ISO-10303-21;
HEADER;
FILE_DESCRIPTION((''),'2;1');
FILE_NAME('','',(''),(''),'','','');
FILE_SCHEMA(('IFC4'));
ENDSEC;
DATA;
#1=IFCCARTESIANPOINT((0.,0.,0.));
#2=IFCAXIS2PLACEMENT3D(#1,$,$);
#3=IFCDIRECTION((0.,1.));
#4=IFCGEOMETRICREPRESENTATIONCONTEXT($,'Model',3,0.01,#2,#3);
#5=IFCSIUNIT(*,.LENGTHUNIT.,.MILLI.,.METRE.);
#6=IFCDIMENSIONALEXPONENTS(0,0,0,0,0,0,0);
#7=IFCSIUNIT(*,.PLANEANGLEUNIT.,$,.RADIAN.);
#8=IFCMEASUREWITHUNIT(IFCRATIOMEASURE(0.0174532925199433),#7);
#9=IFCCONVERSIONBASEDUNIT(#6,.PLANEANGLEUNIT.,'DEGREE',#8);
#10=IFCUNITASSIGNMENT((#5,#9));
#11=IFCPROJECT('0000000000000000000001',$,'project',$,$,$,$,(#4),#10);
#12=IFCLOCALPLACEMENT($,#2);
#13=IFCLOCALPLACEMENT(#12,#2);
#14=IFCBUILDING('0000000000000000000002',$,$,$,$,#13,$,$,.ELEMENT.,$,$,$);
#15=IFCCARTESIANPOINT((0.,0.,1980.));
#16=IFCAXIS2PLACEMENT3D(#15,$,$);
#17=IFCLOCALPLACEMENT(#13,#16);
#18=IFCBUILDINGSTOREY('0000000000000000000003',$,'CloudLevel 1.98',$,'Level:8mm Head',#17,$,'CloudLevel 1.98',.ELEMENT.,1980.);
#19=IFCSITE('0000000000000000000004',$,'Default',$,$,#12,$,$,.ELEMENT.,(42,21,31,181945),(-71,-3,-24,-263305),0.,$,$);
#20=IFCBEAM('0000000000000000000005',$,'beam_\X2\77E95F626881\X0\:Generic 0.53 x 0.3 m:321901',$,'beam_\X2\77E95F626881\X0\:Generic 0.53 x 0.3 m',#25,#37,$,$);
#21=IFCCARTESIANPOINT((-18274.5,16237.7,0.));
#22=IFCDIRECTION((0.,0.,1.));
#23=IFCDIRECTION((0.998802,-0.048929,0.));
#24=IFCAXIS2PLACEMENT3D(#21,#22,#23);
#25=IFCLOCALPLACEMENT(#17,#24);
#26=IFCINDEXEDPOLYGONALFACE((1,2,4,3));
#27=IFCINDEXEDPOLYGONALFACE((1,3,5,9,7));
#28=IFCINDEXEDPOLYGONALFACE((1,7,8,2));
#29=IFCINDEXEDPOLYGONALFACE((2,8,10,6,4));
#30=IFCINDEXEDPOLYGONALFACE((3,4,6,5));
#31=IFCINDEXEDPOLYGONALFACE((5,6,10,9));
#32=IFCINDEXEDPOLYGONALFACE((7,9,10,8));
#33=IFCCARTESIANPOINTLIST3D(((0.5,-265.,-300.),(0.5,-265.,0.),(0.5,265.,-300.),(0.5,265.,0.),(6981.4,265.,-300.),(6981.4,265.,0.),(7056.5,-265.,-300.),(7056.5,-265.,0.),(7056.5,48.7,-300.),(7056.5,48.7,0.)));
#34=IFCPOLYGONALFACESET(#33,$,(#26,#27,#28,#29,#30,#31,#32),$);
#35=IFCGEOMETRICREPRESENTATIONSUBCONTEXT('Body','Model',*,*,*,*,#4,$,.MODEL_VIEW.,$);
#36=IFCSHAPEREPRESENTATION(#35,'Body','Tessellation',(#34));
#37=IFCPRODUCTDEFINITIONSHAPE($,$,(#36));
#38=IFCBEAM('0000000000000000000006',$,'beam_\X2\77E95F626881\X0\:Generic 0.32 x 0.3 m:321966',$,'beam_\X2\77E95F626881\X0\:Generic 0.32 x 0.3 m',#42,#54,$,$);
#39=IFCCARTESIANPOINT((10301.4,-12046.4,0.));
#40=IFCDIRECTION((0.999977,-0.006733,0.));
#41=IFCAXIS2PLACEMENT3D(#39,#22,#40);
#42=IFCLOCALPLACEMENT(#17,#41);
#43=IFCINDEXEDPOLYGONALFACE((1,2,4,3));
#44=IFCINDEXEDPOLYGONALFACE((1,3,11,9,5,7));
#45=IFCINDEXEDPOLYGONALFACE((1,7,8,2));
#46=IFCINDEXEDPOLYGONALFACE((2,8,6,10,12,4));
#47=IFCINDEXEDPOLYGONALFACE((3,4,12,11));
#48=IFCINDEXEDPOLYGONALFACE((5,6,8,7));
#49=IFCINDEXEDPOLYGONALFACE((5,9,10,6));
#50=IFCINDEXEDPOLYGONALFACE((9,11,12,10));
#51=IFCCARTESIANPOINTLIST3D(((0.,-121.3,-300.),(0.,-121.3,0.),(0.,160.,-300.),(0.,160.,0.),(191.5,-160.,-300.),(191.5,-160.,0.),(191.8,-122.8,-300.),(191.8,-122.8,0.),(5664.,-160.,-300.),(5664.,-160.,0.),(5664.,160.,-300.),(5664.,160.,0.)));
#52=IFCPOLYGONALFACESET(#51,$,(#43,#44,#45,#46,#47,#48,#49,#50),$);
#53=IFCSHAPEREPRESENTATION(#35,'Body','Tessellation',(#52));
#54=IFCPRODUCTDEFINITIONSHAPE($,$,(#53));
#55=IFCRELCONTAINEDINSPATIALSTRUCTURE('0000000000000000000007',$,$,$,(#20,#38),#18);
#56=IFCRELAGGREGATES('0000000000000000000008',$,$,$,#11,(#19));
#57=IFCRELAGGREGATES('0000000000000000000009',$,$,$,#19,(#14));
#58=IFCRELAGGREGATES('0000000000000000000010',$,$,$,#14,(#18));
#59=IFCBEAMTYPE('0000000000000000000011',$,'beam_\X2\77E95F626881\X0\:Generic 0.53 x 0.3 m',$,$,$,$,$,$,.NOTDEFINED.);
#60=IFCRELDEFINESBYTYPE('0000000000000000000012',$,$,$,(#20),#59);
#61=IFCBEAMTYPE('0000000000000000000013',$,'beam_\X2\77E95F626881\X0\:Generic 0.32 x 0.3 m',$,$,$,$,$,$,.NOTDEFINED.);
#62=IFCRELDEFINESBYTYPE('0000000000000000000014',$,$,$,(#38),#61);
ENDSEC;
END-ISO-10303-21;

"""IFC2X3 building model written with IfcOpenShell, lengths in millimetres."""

from ifc_helpers import new_model, entity, si_unit, converted_unit, direction, frame, frame_2d, origin, place, context, subcontext, project, spatial, polyline, rectangle, extrude, clip, halfspace, bounded_halfspace, type_object, element, save


model = new_model("IFC2X3")

# Units and contexts
model_context = context("Model", 3, precision=0.01, world=origin(), true_north=direction((0.0, 1.0)))
body_context = subcontext(model_context, "Body", "Model", "MODEL_VIEW")
ifc_project = project(units=[si_unit("LENGTHUNIT", "METRE", prefix="MILLI"), converted_unit("PLANEANGLEUNIT", "DEGREE", entity("IfcRatioMeasure", 0.0174532925199433), si_unit("PLANEANGLEUNIT", "RADIAN"), dimensions=[0, 0, 0, 0, 0, 0, 0])], contexts=[model_context])

# Site, building, storey
site_placement = place(None, origin())
site = spatial("IfcSite", under=ifc_project, at=site_placement, Name="Default", CompositionType="ELEMENT", RefLatitude=(42, 21, 31, 181945), RefLongitude=(-71, -3, -24, -263305), RefElevation=0.0)
building_placement = place(site_placement, origin())
building = spatial("IfcBuilding", under=site, at=building_placement, CompositionType="ELEMENT")
storey_placement = place(building_placement, frame((0.0, 0.0, 1980.0)))
storey = spatial("IfcBuildingStorey", under=building, at=storey_placement, Name="CloudLevel 1.98", ObjectType="Level:8mm Head", LongName="CloudLevel 1.98", CompositionType="ELEMENT", Elevation=1980.0)

# Beams
beam_type_1 = type_object("IfcBeamType", Name="beam_矩形梁:Generic 0.53 x 0.3 m", PredefinedType="NOTDEFINED")
beam_1_placement = place(storey_placement, frame((-18274.5, 16237.7, 0.0), z_axis=(0.0, 0.0, 1.0), x_axis=(0.998802, -0.048929, 0.0)))
element("IfcBeam", 1, at=beam_1_placement, inside=storey, type_object=beam_type_1, Name="beam_矩形梁:Generic 0.53 x 0.3 m:321901", ObjectType="beam_矩形梁:Generic 0.53 x 0.3 m", context=body_context, shape_type="SweptSolid", body=[
    clip(extrude(rectangle(XDim=300.0, YDim=530.0, at=frame_2d((0.0, 0.0), x_axis=(1.0, 0.0))), frame((0.5, 0.0, -150.0), z_axis=(1.0, 0.0, 0.0), x_axis=(0.0, 0.0, -1.0)), (0.0, 0.0, 1.0), 7056.0), halfspace(frame((7054.7, 53.9, -150.0), z_axis=(0.944706, 0.327917, 0.0), x_axis=(0.0, 0.0, 1.0)), False)),
])
beam_type_2 = type_object("IfcBeamType", Name="beam_矩形梁:Generic 0.32 x 0.3 m", PredefinedType="NOTDEFINED")
beam_2_placement = place(storey_placement, frame((10301.4, -12046.4, 0.0), z_axis=(0.0, 0.0, 1.0), x_axis=(0.999977, -0.006733, 0.0)))
element("IfcBeam", 2, at=beam_2_placement, inside=storey, type_object=beam_type_2, Name="beam_矩形梁:Generic 0.32 x 0.3 m:321966", ObjectType="beam_矩形梁:Generic 0.32 x 0.3 m", context=body_context, shape_type="SweptSolid", body=[
    clip(clip(extrude(rectangle(XDim=300.0, YDim=320.0, at=frame_2d((0.0, 0.0), x_axis=(1.0, 0.0))), frame((0.0, 0.0, -150.0), z_axis=(1.0, 0.0, 0.0), x_axis=(0.0, 0.0, -1.0)), (0.0, 0.0, 1.0), 5664.0), bounded_halfspace(frame((191.8, -122.8, 0.0), z_axis=(-0.999966, 0.008232, 0.0), x_axis=(-0.008232, -0.999966, 0.0)), False, frame((0.0, 0.0, -150.0), z_axis=(1.0, 0.0, 0.0), x_axis=(0.0, 0.0, -1.0)), polyline([(-150.0, -122.8), (150.0, -122.8), (150.0, -160.0), (-150.0, -160.0), (-150.0, -122.8)]))), bounded_halfspace(frame((-8.2, -121.2, -150.0), z_axis=(-0.008232, -0.999966, 0.0), x_axis=(0.0, 0.0, 1.0)), False, frame((0.0, 0.0, -150.0), z_axis=(1.0, 0.0, 0.0), x_axis=(0.0, 0.0, -1.0)), polyline([(150.0, -122.8), (-150.0, -122.8), (-150.0, -121.3), (150.0, -121.3), (150.0, -122.8)]))),
])

save(model, "model.ifc")
